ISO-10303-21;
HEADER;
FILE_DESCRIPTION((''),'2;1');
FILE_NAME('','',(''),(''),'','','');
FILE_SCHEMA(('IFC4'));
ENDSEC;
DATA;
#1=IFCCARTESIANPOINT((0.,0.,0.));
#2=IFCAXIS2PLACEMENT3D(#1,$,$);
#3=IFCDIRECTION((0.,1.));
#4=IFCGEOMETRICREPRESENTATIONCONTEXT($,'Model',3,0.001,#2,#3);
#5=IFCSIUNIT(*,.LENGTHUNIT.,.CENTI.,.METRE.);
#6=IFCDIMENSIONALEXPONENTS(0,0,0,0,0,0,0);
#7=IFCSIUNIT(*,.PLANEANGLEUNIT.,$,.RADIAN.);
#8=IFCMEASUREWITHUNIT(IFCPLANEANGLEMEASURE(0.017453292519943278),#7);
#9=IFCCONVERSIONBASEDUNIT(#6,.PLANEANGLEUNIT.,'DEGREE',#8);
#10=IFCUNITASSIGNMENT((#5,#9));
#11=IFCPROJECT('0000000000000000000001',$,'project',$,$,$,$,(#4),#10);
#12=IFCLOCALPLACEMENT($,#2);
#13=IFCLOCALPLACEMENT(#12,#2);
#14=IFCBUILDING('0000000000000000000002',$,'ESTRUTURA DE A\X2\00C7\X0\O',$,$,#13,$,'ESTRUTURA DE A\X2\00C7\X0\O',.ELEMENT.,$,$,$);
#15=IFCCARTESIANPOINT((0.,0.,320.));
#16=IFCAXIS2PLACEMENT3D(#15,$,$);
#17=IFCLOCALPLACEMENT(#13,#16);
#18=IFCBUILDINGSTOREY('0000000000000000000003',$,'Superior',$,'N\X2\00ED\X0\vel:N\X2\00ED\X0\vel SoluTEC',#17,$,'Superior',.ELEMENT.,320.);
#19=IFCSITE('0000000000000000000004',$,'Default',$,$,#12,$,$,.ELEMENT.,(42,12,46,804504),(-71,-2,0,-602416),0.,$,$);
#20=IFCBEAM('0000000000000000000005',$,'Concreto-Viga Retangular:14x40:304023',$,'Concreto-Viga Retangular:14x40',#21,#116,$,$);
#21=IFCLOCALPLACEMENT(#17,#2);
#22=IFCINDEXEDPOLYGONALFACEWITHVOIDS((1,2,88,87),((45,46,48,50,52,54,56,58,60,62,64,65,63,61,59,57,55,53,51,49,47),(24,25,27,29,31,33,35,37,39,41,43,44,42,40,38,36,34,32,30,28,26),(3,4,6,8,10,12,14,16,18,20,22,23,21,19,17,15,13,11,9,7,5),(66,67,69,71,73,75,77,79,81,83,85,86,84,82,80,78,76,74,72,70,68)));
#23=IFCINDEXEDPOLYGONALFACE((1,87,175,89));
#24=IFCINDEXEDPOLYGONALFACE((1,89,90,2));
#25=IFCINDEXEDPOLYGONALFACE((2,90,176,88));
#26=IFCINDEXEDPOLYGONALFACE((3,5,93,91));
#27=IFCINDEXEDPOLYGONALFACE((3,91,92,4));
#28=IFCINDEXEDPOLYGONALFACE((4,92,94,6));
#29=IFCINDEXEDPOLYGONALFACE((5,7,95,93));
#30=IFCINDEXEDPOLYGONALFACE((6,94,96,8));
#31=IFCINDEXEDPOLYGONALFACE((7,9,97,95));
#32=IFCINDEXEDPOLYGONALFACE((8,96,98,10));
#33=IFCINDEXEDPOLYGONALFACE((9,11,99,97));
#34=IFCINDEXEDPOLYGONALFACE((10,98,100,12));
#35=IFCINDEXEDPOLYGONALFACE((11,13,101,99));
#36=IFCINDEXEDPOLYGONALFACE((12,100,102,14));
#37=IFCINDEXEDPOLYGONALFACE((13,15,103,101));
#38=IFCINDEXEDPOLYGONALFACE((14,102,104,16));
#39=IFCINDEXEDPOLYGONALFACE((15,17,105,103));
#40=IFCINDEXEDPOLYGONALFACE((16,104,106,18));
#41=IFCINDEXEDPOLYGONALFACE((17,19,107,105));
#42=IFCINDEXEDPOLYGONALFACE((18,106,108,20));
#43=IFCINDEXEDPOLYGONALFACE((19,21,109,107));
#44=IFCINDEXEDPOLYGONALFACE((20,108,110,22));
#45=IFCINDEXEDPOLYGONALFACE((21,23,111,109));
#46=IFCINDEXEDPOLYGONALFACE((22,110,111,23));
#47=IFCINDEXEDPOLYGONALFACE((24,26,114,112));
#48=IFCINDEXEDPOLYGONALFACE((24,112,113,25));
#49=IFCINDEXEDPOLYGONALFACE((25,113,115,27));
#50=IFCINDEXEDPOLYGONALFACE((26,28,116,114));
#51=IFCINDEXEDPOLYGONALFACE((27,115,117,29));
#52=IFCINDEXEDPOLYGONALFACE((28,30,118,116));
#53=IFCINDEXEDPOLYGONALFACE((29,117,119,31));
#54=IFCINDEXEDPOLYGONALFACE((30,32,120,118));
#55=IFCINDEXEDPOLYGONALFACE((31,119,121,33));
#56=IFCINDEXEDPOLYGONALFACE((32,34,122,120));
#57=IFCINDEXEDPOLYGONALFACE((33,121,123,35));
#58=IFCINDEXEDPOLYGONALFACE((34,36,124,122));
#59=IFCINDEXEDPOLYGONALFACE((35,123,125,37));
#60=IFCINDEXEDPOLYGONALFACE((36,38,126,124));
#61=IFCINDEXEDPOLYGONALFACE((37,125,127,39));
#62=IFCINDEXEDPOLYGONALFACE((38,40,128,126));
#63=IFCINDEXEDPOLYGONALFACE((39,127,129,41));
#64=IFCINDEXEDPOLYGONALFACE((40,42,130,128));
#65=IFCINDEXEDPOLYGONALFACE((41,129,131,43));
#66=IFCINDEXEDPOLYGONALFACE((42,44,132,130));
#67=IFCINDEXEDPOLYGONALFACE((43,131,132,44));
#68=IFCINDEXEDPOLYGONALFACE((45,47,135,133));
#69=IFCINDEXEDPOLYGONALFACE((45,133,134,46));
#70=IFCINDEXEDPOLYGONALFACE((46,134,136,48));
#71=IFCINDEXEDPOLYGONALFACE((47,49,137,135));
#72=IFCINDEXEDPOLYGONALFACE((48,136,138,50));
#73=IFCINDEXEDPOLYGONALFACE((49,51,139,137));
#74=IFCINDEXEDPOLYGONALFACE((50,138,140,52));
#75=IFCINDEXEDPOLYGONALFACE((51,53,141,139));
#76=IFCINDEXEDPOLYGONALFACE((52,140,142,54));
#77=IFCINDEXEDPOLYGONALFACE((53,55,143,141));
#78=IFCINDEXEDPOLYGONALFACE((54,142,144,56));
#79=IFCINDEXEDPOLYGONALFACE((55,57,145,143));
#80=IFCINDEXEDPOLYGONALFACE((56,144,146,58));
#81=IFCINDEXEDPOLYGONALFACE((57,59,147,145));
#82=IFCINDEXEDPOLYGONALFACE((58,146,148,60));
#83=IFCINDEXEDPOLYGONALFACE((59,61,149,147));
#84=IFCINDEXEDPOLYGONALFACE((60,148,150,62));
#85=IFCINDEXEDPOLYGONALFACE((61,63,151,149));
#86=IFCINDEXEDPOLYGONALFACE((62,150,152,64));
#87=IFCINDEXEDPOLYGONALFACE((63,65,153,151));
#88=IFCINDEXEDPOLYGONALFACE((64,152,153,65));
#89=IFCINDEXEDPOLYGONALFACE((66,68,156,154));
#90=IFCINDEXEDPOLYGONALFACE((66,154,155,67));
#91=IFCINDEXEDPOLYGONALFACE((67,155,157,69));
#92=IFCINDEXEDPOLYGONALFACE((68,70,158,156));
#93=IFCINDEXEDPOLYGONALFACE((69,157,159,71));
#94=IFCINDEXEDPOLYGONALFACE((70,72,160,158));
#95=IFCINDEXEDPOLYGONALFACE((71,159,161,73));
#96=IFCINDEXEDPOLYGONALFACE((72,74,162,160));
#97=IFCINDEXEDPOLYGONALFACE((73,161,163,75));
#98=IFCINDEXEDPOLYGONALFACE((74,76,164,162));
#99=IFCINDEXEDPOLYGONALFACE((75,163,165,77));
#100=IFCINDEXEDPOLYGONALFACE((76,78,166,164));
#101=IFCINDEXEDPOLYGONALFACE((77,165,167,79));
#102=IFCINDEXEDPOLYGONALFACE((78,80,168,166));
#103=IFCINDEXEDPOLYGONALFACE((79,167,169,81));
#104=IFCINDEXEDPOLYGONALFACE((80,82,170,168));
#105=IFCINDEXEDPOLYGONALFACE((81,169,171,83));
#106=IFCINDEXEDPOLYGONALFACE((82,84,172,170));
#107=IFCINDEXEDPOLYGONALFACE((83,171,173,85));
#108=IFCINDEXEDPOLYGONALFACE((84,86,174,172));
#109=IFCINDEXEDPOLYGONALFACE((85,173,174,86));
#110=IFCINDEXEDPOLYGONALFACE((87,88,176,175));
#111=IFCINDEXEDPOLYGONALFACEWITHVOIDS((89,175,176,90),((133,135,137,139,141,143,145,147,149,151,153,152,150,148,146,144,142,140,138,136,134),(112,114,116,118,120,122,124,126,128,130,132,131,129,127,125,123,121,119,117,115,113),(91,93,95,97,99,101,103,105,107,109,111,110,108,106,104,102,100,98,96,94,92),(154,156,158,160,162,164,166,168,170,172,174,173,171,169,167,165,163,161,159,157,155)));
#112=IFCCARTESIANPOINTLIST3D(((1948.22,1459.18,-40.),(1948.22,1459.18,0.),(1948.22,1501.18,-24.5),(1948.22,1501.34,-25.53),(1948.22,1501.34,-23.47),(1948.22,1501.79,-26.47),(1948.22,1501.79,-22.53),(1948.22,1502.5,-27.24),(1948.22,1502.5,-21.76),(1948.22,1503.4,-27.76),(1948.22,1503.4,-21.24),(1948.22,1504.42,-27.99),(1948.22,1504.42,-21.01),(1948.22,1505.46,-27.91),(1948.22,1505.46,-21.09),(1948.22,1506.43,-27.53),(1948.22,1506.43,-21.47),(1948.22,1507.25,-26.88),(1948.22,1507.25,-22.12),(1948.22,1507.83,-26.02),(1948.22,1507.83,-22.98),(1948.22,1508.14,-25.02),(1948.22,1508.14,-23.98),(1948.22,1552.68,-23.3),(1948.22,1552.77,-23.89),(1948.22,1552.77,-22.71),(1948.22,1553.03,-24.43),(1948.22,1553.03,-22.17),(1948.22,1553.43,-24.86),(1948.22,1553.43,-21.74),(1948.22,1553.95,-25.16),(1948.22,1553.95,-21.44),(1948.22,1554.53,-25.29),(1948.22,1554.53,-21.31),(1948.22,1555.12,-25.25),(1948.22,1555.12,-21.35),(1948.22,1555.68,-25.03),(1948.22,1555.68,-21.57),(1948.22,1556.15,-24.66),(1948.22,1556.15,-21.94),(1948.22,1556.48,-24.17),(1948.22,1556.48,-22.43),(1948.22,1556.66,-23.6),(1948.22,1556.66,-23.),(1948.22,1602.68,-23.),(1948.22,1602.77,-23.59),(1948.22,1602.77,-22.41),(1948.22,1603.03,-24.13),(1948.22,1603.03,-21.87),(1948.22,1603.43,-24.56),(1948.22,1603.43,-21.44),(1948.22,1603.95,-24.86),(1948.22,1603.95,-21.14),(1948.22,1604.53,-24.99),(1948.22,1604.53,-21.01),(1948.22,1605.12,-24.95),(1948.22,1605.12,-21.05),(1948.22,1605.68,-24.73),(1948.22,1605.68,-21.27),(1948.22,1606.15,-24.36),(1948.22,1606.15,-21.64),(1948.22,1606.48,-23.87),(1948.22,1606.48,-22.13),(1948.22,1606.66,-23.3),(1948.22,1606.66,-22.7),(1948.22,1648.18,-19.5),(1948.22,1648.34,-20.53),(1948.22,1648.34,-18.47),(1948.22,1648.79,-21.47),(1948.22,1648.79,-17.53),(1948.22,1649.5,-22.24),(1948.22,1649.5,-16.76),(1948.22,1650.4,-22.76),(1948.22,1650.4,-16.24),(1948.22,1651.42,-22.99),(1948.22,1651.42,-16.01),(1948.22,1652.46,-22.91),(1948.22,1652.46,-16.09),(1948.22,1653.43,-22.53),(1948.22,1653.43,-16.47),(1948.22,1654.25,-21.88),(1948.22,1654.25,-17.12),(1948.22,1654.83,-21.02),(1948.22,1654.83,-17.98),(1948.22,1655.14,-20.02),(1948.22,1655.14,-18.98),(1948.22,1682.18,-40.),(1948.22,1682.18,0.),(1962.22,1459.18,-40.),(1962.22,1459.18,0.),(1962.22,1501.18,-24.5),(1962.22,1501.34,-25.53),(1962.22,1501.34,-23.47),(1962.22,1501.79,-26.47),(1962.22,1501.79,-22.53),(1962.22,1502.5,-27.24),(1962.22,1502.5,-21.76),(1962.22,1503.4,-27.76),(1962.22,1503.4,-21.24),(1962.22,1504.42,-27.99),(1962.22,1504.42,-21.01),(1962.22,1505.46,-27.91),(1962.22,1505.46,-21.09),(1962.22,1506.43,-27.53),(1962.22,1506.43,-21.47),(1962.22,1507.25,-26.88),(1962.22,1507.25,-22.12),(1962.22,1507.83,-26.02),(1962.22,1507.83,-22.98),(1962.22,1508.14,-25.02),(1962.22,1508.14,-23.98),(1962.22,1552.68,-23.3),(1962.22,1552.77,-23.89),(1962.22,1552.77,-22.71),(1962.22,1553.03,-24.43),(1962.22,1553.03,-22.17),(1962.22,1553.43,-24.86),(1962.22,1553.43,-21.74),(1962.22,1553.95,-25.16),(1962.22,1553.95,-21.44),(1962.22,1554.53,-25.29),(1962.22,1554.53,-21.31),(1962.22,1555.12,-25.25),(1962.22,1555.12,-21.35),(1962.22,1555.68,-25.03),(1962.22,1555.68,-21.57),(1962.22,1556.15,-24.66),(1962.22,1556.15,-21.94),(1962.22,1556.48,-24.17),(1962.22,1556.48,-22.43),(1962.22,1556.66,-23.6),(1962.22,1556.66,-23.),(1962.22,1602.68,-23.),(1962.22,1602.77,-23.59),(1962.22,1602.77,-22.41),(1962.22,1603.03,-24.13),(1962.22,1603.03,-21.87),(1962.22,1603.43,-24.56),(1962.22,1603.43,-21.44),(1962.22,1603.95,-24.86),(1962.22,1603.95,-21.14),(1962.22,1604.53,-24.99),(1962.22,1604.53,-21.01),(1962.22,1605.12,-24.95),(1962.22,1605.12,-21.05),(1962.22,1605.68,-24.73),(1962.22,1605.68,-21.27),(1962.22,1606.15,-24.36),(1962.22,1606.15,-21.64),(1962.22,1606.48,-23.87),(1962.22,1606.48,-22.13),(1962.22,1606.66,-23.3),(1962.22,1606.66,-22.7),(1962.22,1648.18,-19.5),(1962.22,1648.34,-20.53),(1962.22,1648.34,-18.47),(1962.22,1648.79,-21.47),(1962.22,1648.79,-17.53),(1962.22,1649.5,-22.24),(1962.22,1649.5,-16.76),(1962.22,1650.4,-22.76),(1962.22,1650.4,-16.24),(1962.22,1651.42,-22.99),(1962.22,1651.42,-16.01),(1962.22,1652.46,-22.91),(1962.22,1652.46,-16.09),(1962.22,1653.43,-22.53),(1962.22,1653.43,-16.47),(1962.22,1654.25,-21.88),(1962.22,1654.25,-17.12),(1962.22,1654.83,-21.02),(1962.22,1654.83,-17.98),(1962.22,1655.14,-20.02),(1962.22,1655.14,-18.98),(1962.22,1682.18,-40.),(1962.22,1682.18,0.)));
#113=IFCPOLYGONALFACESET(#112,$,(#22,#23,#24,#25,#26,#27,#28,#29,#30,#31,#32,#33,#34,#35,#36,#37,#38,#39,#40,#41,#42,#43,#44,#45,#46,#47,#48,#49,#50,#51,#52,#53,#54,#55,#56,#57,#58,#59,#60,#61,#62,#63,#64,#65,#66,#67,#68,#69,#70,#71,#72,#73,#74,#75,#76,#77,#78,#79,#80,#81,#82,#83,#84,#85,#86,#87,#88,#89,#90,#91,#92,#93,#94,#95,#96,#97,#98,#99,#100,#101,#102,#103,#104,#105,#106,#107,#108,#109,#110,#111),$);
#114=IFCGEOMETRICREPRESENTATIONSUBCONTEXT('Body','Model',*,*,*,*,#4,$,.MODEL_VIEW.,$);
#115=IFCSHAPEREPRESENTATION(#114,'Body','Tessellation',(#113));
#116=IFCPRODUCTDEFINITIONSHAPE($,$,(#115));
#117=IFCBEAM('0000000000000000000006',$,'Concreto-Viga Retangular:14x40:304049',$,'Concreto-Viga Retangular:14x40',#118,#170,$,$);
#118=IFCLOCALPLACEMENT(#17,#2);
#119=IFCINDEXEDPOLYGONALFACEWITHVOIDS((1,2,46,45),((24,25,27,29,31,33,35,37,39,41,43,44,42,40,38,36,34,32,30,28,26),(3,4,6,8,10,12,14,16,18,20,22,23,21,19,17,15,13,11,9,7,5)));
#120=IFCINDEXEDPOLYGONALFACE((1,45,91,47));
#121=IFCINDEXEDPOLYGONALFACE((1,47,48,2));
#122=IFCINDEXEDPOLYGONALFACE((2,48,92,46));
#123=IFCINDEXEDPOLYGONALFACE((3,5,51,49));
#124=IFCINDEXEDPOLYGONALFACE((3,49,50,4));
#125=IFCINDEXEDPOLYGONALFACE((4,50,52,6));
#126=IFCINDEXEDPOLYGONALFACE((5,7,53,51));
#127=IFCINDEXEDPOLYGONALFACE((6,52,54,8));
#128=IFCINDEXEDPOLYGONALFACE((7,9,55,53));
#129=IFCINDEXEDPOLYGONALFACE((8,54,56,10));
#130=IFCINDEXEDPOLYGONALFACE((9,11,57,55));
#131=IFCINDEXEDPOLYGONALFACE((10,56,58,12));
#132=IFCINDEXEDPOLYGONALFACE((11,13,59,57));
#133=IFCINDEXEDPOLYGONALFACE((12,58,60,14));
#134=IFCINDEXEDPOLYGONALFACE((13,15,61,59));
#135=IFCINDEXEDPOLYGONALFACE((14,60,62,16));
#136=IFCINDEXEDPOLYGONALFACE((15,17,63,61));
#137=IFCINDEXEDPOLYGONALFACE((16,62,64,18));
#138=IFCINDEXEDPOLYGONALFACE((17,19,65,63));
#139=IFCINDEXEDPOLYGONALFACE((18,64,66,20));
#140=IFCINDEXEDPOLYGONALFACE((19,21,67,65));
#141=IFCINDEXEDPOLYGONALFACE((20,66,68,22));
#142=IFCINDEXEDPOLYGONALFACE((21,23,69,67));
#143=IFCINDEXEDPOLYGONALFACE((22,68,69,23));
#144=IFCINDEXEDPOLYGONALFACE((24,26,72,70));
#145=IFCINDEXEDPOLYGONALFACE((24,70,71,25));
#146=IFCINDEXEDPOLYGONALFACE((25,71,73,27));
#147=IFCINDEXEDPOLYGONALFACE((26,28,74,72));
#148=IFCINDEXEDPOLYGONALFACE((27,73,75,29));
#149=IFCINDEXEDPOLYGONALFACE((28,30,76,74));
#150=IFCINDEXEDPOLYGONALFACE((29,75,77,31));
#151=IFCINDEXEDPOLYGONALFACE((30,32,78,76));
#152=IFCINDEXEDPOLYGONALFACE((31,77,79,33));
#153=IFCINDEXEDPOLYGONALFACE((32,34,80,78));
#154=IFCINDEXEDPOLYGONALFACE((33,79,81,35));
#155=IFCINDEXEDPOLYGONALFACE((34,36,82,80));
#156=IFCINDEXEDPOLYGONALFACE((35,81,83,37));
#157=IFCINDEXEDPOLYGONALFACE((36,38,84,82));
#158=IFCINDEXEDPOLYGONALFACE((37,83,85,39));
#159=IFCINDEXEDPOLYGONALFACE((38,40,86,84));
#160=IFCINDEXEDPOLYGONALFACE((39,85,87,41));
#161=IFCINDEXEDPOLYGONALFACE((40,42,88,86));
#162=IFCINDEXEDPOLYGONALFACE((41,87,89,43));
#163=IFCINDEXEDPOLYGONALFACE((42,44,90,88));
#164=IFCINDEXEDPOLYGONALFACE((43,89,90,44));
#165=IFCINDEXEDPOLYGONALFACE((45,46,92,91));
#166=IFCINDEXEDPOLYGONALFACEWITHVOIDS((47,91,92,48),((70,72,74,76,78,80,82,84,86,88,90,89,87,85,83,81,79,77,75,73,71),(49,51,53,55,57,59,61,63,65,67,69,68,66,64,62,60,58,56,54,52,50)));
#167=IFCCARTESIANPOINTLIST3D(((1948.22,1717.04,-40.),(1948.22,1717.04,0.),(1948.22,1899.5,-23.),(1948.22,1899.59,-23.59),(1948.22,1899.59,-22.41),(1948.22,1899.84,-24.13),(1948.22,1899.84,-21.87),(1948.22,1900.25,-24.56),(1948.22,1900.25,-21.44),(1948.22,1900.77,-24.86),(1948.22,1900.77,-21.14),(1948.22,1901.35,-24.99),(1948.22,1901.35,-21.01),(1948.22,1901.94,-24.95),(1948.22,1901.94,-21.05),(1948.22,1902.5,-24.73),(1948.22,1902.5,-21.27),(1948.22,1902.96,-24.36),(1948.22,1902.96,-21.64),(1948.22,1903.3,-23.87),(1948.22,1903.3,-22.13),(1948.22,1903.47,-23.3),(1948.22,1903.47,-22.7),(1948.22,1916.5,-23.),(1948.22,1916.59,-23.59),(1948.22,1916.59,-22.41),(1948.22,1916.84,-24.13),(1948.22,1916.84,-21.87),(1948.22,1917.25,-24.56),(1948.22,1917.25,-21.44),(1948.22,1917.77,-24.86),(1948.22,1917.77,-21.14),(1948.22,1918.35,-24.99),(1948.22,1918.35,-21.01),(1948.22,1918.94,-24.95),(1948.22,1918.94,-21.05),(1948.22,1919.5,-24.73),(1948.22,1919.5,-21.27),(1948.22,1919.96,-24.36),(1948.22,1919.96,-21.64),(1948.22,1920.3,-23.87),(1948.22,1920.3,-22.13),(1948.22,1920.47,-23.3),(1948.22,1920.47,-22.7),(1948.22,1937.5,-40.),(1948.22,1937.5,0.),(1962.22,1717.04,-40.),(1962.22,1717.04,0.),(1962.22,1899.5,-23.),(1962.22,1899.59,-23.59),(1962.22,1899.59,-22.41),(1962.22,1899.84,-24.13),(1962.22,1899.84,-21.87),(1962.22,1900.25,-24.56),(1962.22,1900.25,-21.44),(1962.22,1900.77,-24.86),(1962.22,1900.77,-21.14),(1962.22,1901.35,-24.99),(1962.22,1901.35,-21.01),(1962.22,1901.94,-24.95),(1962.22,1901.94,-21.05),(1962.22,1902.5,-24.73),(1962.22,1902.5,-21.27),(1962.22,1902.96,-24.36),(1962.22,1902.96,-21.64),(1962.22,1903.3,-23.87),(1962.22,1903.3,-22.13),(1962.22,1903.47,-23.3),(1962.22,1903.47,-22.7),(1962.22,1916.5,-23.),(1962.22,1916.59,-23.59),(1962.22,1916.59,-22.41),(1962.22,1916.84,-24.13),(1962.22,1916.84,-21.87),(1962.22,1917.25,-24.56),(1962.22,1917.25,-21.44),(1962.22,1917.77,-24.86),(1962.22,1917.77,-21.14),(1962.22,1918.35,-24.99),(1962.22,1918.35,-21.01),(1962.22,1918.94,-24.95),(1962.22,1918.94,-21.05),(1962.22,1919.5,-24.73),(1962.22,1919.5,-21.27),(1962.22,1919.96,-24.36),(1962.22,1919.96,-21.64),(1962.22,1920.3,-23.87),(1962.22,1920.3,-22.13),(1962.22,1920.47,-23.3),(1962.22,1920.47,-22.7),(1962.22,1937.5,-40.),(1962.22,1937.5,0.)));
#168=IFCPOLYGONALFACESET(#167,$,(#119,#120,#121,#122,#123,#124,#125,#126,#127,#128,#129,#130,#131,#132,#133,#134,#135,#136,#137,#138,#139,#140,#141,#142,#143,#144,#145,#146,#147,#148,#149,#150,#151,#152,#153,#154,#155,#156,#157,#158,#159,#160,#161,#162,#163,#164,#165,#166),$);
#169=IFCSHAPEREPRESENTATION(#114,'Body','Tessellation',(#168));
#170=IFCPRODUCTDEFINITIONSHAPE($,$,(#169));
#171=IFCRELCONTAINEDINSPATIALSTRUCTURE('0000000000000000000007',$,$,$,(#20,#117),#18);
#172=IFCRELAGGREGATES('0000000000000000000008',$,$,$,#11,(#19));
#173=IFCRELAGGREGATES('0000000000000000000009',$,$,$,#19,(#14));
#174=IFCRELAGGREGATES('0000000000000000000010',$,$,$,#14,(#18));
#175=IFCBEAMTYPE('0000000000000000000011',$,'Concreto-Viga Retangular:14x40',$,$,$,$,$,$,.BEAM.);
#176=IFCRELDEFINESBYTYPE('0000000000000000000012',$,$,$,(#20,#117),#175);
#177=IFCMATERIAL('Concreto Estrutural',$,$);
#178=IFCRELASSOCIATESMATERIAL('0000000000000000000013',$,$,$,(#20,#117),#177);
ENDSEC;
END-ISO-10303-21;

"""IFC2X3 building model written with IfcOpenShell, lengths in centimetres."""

from ifc_helpers import new_model, entity, si_unit, converted_unit, direction, frame, frame_2d, origin, origin_2d_with_axis, place, context, subcontext, project, spatial, rectangle, circle, extrude, boolean, material, type_object, element, save


model = new_model("IFC2X3")

# Units and contexts
model_context = context("Model", 3, precision=0.001, world=origin(), true_north=direction((0.0, 1.0)))
body_context = subcontext(model_context, "Body", "Model", "MODEL_VIEW")
ifc_project = project(units=[si_unit("LENGTHUNIT", "METRE", prefix="CENTI"), converted_unit("PLANEANGLEUNIT", "DEGREE", entity("IfcPlaneAngleMeasure", 0.017453292519943278), si_unit("PLANEANGLEUNIT", "RADIAN"), dimensions=[0, 0, 0, 0, 0, 0, 0])], contexts=[model_context])

# Site, building, storey
site_placement = place(None, origin())
site = spatial("IfcSite", under=ifc_project, at=site_placement, Name="Default", CompositionType="ELEMENT", RefLatitude=(42, 12, 46, 804504), RefLongitude=(-71, -2, 0, -602416), RefElevation=0.0)
building_placement = place(site_placement, origin())
building = spatial("IfcBuilding", under=site, at=building_placement, Name="ESTRUTURA DE AÇO", LongName="ESTRUTURA DE AÇO", CompositionType="ELEMENT")
storey_placement = place(building_placement, frame((0.0, 0.0, 320.0)))
storey = spatial("IfcBuildingStorey", under=building, at=storey_placement, Name="Superior", ObjectType="Nível:Nível SoluTEC", LongName="Superior", CompositionType="ELEMENT", Elevation=320.0)

# Shared definitions
ifc_material = material(Name="Concreto Estrutural")

# Beams
beam_type_1 = type_object("IfcBeamType", Name="Concreto-Viga Retangular:14x40", PredefinedType="BEAM")
beam_1_placement = place(storey_placement, frame((1955.22, 1682.18, 0.0), z_axis=(0.0, 0.0, 1.0), x_axis=(0.0, -1.0, 0.0)))
element("IfcBeam", 1, at=beam_1_placement, inside=storey, type_object=beam_type_1, material=ifc_material, Name="Concreto-Viga Retangular:14x40:304023", ObjectType="Concreto-Viga Retangular:14x40", context=body_context, shape_type="SweptSolid", body=[
    boolean("DIFFERENCE", boolean("DIFFERENCE", boolean("DIFFERENCE", boolean("DIFFERENCE", extrude(rectangle(XDim=40.0, YDim=14.0, at=frame_2d((0.0, 0.0), x_axis=(0.0, 1.0))), frame((0.0, 0.0, -20.0), z_axis=(1.0, 0.0, 0.0), x_axis=(0.0, 1.0, 0.0)), (0.0, 0.0, 1.0), 223.0), extrude(circle(Radius=2.0, at=origin_2d_with_axis()), frame((127.5, 7.0, -23.3), z_axis=(0.0, -1.0, 0.0), x_axis=(1.0, 0.0, 0.0)), (0.0, 0.0, 1.0), 14.0)), extrude(circle(Radius=3.5, at=origin_2d_with_axis()), frame((177.5, 7.0, -24.5), z_axis=(0.0, -1.0, 0.0), x_axis=(1.0, 0.0, 0.0)), (0.0, 0.0, 1.0), 14.0)), extrude(circle(Radius=3.5, at=origin_2d_with_axis()), frame((30.5, 7.0, -19.5), z_axis=(0.0, -1.0, 0.0), x_axis=(1.0, 0.0, 0.0)), (0.0, 0.0, 1.0), 14.0)), extrude(circle(Radius=2.0, at=origin_2d_with_axis()), frame((77.5, 7.0, -23.0), z_axis=(0.0, -1.0, 0.0), x_axis=(1.0, 0.0, 0.0)), (0.0, 0.0, 1.0), 14.0)),
])
beam_2_placement = place(storey_placement, frame((1955.22, 1947.0, 0.0), z_axis=(0.0, 0.0, 1.0), x_axis=(0.0, -1.0, 0.0)))
element("IfcBeam", 2, at=beam_2_placement, inside=storey, type_object=beam_type_1, material=ifc_material, Name="Concreto-Viga Retangular:14x40:304049", ObjectType="Concreto-Viga Retangular:14x40", context=body_context, shape_type="SweptSolid", body=[
    boolean("DIFFERENCE", boolean("DIFFERENCE", extrude(rectangle(XDim=40.0, YDim=14.0, at=frame_2d((0.0, 0.0), x_axis=(0.0, 1.0))), frame((9.5, 0.0, -20.0), z_axis=(1.0, 0.0, 0.0), x_axis=(0.0, 1.0, 0.0)), (0.0, 0.0, 1.0), 220.46), extrude(circle(Radius=2.0, at=origin_2d_with_axis()), frame((28.5, 7.0, -23.0), z_axis=(0.0, -1.0, 0.0), x_axis=(1.0, 0.0, 0.0)), (0.0, 0.0, 1.0), 14.0)), extrude(circle(Radius=2.0, at=origin_2d_with_axis()), frame((45.5, 7.0, -23.0), z_axis=(0.0, -1.0, 0.0), x_axis=(1.0, 0.0, 0.0)), (0.0, 0.0, 1.0), 14.0)),
])

save(model, "model.ifc")
